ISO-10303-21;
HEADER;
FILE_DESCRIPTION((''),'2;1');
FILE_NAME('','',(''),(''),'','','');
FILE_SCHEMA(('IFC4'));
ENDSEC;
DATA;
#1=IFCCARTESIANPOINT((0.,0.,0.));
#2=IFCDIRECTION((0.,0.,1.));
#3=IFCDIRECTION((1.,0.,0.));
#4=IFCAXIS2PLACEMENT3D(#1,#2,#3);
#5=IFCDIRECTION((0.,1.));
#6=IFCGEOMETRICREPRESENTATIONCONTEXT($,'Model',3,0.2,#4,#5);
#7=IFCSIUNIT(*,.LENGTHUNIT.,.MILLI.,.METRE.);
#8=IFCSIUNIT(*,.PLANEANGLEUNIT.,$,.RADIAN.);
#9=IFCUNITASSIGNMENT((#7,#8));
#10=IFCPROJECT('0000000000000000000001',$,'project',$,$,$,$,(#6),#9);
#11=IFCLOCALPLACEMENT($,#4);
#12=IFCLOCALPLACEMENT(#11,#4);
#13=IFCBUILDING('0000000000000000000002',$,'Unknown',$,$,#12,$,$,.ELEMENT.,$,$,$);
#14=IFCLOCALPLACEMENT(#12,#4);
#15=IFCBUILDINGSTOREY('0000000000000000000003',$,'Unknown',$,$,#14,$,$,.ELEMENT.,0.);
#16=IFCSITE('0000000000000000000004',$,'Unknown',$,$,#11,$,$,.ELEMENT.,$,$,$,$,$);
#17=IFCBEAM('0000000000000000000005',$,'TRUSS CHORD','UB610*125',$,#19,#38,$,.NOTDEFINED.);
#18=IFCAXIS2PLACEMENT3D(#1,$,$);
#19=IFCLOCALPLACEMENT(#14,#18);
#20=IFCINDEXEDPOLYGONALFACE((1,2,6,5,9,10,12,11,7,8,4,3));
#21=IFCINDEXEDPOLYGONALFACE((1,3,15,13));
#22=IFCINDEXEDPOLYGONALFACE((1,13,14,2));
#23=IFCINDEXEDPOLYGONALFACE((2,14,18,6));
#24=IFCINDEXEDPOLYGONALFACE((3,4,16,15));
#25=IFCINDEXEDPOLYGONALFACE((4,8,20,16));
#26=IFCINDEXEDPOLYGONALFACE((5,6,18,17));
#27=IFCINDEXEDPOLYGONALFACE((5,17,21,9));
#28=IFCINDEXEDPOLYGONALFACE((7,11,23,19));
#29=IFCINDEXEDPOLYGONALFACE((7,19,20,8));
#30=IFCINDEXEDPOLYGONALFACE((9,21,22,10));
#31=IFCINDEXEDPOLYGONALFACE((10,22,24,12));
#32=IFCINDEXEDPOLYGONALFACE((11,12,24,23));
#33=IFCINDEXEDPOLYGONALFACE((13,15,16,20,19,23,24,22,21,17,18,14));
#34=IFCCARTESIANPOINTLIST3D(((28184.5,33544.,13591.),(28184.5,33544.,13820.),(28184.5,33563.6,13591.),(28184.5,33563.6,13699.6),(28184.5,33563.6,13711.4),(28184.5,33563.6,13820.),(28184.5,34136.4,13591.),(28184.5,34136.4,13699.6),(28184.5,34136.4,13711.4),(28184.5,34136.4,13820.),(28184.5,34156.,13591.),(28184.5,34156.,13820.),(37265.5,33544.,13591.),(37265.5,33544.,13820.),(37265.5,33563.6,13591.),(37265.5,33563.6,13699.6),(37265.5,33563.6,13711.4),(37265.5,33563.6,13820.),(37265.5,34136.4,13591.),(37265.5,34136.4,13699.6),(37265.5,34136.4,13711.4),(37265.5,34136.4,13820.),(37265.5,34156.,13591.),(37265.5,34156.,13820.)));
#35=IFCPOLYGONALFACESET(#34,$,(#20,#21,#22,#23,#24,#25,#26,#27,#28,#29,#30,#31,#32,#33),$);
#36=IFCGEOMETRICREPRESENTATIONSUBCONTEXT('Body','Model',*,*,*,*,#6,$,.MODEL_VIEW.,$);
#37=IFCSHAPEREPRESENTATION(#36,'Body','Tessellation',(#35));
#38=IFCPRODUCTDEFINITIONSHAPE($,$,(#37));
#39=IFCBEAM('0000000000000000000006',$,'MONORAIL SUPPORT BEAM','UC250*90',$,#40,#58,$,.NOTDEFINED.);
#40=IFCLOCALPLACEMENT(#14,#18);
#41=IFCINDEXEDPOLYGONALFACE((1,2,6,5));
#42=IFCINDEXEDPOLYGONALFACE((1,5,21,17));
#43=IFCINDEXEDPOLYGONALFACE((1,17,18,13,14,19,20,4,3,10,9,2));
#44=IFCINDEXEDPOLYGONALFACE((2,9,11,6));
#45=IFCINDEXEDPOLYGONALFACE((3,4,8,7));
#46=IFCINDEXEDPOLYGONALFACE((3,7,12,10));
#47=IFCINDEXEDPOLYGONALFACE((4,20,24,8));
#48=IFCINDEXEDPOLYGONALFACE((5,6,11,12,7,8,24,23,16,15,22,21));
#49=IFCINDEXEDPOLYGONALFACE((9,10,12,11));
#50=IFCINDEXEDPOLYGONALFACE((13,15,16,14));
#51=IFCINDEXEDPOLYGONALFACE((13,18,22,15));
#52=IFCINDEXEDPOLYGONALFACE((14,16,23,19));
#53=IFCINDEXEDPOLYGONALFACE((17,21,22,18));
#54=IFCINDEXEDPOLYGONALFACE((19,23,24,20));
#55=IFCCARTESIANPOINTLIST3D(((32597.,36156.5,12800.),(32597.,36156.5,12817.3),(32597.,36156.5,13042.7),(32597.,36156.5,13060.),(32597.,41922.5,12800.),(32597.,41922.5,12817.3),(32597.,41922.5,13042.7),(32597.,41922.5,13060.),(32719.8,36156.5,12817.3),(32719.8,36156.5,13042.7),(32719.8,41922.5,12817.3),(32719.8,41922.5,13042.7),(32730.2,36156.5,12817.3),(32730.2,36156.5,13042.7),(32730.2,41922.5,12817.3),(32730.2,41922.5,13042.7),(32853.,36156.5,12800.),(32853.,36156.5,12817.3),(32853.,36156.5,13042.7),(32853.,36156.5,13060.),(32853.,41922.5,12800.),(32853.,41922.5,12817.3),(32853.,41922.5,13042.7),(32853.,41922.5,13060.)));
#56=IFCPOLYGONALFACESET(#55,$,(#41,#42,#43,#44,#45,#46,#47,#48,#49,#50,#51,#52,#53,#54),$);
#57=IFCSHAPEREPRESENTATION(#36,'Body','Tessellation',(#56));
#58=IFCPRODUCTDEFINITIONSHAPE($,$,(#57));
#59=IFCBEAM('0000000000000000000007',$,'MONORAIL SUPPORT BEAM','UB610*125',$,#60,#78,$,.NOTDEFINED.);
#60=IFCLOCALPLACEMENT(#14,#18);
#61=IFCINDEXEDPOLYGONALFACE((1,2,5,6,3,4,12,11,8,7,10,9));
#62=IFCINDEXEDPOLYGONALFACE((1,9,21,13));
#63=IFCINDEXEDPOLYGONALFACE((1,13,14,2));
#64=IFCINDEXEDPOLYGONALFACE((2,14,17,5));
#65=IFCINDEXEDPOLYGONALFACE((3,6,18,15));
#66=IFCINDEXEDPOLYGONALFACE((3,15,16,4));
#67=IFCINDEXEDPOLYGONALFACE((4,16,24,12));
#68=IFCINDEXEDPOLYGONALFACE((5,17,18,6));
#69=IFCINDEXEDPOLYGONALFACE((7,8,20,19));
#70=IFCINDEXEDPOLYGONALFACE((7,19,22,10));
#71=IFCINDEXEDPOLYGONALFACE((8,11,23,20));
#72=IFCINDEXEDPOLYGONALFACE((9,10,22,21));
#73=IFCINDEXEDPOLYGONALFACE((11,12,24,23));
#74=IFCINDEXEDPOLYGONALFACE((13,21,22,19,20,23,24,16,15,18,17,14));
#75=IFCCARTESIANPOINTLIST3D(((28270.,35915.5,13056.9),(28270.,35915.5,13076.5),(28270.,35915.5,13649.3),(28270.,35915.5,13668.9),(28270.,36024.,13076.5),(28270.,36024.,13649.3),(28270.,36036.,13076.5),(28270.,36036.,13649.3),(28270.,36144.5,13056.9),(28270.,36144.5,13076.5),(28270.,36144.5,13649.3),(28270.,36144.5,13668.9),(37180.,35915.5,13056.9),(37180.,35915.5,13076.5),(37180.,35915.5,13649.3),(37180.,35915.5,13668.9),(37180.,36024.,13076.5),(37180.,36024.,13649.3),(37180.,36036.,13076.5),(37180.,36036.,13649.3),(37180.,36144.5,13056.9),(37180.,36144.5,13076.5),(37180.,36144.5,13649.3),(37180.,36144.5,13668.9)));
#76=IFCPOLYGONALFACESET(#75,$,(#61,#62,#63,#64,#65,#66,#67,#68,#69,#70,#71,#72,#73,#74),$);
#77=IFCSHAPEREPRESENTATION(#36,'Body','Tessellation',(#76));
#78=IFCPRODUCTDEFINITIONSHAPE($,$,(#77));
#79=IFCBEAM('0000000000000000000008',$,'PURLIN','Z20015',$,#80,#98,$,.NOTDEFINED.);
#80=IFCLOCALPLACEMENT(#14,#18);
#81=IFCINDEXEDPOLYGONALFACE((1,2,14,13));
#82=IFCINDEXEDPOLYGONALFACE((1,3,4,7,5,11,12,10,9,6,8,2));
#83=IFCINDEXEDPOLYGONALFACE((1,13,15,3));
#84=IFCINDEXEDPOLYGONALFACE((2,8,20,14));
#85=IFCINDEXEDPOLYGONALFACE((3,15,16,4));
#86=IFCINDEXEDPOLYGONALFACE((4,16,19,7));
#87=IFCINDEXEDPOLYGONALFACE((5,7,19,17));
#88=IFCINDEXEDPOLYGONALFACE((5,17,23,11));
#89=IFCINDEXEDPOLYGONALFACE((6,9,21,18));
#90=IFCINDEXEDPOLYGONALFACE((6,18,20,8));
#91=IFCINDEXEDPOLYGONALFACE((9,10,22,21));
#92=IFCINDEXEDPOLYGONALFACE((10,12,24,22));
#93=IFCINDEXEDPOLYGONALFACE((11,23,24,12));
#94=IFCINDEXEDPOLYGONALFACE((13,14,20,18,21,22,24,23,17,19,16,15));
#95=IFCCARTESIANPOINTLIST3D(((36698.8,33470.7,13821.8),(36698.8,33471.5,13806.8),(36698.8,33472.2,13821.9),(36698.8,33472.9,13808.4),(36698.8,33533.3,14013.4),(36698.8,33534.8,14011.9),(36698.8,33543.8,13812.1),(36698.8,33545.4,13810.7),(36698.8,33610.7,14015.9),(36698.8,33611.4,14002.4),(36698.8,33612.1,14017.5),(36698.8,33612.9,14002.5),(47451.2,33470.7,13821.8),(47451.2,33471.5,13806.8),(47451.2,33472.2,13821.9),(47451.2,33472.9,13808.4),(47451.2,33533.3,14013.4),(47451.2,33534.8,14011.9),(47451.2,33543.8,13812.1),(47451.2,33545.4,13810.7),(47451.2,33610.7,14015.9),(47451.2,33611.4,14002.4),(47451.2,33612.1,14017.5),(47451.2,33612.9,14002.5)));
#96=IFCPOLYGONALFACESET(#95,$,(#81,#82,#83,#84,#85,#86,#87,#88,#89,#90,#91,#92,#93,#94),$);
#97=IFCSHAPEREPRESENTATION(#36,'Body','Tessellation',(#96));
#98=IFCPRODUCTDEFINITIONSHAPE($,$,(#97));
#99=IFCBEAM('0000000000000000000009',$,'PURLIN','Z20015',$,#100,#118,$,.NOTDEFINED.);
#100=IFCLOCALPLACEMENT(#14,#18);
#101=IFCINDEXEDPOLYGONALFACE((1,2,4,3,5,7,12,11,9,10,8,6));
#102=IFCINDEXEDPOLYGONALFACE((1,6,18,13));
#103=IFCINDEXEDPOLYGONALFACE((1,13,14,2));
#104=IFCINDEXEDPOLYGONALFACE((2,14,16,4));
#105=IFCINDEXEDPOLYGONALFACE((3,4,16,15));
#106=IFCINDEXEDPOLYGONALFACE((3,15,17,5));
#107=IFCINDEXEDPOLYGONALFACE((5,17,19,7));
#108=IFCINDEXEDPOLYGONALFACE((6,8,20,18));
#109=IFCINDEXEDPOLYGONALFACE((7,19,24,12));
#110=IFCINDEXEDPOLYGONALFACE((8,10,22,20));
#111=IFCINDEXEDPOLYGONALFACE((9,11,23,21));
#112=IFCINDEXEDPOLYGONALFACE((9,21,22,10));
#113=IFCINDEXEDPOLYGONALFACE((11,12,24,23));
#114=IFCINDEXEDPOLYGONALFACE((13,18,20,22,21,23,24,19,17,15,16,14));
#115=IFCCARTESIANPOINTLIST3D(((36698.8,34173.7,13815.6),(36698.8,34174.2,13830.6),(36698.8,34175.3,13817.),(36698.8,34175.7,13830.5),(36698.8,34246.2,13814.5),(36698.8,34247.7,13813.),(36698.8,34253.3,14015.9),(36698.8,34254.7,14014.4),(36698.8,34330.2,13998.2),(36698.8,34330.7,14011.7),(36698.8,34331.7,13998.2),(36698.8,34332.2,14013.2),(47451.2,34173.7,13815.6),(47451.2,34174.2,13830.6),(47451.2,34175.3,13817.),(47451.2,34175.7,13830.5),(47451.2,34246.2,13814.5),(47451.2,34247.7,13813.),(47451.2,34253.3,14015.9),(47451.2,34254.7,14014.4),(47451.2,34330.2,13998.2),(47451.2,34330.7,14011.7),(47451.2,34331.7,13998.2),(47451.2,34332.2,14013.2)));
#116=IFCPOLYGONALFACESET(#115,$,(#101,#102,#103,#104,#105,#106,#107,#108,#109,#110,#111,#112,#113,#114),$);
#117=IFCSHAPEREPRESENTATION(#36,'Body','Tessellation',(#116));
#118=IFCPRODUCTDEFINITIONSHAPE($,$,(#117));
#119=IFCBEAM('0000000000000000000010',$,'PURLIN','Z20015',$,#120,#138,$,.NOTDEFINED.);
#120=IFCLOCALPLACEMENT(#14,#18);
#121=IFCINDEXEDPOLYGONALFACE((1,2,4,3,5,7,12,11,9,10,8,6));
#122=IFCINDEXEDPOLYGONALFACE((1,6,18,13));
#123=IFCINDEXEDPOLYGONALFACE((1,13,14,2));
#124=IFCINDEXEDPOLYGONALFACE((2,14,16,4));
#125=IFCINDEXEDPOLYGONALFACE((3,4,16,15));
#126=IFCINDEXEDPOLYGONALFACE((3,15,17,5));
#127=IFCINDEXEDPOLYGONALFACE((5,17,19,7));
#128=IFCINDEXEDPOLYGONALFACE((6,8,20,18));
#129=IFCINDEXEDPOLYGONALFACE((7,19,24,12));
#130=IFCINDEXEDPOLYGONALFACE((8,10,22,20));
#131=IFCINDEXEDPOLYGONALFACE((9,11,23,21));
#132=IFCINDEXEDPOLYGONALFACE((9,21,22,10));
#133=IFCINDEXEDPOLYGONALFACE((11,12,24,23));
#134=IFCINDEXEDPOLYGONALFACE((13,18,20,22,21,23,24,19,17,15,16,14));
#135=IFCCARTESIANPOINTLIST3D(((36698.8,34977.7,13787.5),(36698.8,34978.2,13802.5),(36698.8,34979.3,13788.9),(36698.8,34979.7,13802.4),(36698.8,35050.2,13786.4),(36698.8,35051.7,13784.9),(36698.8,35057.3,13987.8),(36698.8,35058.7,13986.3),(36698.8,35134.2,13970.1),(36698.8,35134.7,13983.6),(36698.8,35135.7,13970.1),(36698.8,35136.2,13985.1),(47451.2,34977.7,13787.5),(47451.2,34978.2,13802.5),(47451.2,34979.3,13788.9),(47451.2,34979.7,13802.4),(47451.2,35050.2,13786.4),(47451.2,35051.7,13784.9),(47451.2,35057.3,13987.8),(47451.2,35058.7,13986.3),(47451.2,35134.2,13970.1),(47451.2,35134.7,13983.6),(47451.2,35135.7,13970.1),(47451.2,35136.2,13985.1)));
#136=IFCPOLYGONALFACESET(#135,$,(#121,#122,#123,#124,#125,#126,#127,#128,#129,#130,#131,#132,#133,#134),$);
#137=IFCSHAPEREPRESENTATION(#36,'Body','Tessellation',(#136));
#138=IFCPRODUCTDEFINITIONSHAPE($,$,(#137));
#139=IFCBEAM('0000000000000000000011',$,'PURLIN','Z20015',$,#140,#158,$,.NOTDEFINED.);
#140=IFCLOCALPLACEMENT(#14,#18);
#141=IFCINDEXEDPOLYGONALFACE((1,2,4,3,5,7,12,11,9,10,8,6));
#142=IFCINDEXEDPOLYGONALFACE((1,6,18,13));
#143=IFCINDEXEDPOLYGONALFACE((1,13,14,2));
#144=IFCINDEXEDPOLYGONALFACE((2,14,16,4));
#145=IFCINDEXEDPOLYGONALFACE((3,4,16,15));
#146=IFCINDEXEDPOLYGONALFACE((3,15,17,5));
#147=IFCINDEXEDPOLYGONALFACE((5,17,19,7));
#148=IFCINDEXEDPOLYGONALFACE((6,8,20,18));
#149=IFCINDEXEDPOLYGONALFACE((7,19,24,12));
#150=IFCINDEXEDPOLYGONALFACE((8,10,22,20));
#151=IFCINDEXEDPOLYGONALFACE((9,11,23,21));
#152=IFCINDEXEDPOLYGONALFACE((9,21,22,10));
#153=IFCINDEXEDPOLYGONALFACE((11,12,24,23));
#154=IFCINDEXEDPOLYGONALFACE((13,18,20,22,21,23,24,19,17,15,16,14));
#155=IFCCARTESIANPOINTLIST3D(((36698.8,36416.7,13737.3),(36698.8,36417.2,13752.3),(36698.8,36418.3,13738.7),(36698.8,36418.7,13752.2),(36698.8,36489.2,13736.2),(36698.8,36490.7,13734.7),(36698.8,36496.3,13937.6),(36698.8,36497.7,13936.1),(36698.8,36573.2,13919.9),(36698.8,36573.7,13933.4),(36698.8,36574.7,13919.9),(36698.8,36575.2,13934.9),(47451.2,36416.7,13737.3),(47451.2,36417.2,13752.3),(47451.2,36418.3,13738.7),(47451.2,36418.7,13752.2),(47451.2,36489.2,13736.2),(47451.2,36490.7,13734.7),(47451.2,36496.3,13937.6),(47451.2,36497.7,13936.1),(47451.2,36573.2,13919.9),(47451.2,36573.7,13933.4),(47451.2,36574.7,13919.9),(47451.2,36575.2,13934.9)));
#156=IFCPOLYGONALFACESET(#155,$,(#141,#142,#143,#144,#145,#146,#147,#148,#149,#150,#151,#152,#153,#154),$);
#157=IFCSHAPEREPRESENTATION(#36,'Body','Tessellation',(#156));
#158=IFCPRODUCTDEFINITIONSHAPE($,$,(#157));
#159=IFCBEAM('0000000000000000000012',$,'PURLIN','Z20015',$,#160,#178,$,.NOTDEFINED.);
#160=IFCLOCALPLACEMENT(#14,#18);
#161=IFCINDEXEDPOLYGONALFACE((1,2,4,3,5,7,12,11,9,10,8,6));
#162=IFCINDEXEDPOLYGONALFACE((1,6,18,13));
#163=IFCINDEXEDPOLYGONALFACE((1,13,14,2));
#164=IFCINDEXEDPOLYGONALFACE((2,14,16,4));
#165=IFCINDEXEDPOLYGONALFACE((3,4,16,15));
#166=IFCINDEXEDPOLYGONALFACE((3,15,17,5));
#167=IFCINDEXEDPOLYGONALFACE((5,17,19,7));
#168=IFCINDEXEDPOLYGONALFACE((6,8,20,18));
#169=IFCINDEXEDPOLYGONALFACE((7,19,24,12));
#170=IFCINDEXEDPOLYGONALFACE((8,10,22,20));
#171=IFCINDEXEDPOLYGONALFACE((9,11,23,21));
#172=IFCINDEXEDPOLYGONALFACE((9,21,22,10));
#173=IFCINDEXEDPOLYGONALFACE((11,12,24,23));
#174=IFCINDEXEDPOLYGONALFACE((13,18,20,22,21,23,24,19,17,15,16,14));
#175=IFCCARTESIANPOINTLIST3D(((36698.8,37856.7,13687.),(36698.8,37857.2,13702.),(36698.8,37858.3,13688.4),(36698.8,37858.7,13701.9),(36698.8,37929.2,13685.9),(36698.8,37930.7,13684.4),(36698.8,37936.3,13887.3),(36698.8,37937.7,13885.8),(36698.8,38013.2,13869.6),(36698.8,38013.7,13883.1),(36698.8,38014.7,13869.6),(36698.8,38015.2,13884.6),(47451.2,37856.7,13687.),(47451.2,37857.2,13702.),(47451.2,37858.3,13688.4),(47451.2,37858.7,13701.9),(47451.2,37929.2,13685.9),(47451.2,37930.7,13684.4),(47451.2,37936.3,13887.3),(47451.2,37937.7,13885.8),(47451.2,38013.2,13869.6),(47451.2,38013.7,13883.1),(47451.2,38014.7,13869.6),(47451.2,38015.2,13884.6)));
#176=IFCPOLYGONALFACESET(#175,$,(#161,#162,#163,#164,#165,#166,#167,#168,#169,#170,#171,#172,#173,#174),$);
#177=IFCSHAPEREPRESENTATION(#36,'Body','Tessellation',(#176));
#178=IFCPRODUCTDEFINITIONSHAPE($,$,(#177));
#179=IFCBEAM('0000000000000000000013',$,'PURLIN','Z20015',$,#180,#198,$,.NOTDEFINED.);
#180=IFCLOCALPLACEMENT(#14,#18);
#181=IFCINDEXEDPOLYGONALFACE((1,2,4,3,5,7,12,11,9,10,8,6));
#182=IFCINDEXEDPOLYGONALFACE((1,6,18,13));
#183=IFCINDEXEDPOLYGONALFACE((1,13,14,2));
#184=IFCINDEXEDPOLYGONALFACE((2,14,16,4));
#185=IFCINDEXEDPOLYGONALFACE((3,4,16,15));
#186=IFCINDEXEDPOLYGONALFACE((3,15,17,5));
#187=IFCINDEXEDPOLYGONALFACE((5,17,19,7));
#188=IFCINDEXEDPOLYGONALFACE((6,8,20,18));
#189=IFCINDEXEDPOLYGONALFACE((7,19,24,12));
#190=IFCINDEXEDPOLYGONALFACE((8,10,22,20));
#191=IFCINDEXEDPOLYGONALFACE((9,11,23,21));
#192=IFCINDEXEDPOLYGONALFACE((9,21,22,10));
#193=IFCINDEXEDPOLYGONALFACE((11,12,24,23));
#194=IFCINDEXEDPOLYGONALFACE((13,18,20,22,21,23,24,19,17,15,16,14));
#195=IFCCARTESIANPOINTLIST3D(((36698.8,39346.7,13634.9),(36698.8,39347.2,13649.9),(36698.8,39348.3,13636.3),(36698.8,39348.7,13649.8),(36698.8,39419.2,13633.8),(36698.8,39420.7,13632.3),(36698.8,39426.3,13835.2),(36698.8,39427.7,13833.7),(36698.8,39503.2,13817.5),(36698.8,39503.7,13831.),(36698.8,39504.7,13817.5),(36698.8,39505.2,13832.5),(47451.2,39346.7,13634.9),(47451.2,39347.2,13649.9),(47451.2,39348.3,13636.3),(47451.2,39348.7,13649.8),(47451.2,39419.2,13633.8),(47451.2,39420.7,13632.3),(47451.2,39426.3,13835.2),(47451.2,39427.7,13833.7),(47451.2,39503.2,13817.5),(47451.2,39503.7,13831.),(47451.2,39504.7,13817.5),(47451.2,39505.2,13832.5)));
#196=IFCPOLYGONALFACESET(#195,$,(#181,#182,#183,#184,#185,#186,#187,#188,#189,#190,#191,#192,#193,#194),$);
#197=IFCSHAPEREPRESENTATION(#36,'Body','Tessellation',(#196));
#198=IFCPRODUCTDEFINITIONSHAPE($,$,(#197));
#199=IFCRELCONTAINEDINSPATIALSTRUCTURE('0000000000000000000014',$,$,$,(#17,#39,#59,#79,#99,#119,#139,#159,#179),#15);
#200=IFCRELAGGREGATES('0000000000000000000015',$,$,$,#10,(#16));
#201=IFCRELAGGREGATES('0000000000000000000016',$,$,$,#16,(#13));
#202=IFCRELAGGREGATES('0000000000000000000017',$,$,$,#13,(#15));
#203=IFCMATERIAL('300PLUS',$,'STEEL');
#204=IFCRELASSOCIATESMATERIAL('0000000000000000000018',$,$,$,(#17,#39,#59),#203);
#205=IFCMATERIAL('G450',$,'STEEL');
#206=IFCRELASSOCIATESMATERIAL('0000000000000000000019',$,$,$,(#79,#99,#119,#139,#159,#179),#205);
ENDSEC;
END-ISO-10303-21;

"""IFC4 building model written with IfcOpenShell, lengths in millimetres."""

from ifc_helpers import new_model, si_unit, direction, frame, origin_with_axes, place, context, subcontext, project, spatial, line, indexed_curve, outline, extrude, material, element, save


model = new_model("IFC4")

# Units and contexts
model_context = context("Model", 3, precision=0.2, world=origin_with_axes(), true_north=direction((0.0, 1.0)))
body_context = subcontext(model_context, "Body", "Model", "MODEL_VIEW")
ifc_project = project(units=[si_unit("LENGTHUNIT", "METRE", prefix="MILLI"), si_unit("PLANEANGLEUNIT", "RADIAN")], contexts=[model_context])

# Site, building, storey
site_placement = place(None, origin_with_axes())
site = spatial("IfcSite", under=ifc_project, at=site_placement, Name="Unknown", CompositionType="ELEMENT")
building_placement = place(site_placement, origin_with_axes())
building = spatial("IfcBuilding", under=site, at=building_placement, Name="Unknown", CompositionType="ELEMENT")
storey_placement = place(building_placement, origin_with_axes())
storey = spatial("IfcBuildingStorey", under=building, at=storey_placement, Name="Unknown", CompositionType="ELEMENT", Elevation=0.0)

# Beams
ifc_material_1 = material(Name="300PLUS", Category="STEEL")
beam_1_placement = place(storey_placement, frame((28184.5, 33850.0, 13705.5), z_axis=(0.0, 0.0, 1.0), x_axis=(1.0, 0.0, 0.0)))
element("IfcBeam", 1, at=beam_1_placement, inside=storey, material=ifc_material_1, Name="TRUSS CHORD", Description="UB610*125", PredefinedType="NOTDEFINED", context=body_context, shape_type="SolidModel", body=[
    extrude(outline(indexed_curve([(-114.5, -306.0), (114.5, -306.0), (114.5, -286.4), (6.0, -286.4), (6.0, 286.4), (114.5, 286.4), (114.5, 306.0), (-114.5, 306.0), (-114.5, 286.4), (-6.0, 286.4), (-6.0, -286.4), (-114.5, -286.4)], segments=[line(1, 2, 3, 4, 5, 6, 7, 8, 9, 10, 11, 12, 1)])), frame((0.0, 0.0, 0.0), z_axis=(-1.0, 0.0, 0.0), x_axis=(0.0, 0.0, 1.0)), (0.0, 0.0, -1.0), 9081.0),
])
beam_2_placement = place(storey_placement, frame((32725.0, 36156.5, 12930.0), z_axis=(1.0, 0.0, 0.0), x_axis=(0.0, 1.0, 0.0)))
element("IfcBeam", 2, at=beam_2_placement, inside=storey, material=ifc_material_1, Name="MONORAIL SUPPORT BEAM", Description="UC250*90", PredefinedType="NOTDEFINED", context=body_context, shape_type="SolidModel", body=[
    extrude(outline(indexed_curve([(-128.0, -130.0), (128.0, -130.0), (128.0, -112.7), (5.2, -112.7), (5.2, 112.7), (128.0, 112.7), (128.0, 130.0), (-128.0, 130.0), (-128.0, 112.7), (-5.2, 112.7), (-5.2, -112.7), (-128.0, -112.7)], segments=[line(1, 2, 3, 4, 5, 6, 7, 8, 9, 10, 11, 12, 1)])), frame((0.0, 0.0, 0.0), z_axis=(-1.0, 0.0, 0.0), x_axis=(0.0, 0.0, 1.0)), (0.0, 0.0, -1.0), 5766.0),
])
beam_3_placement = place(storey_placement, frame((28270.0, 36030.0, 13362.9), z_axis=(0.0, -1.0, 0.0), x_axis=(1.0, 0.0, 0.0)))
element("IfcBeam", 3, at=beam_3_placement, inside=storey, material=ifc_material_1, Name="MONORAIL SUPPORT BEAM", Description="UB610*125", PredefinedType="NOTDEFINED", context=body_context, shape_type="SolidModel", body=[
    extrude(outline(indexed_curve([(-114.5, -306.0), (114.5, -306.0), (114.5, -286.4), (6.0, -286.4), (6.0, 286.4), (114.5, 286.4), (114.5, 306.0), (-114.5, 306.0), (-114.5, 286.4), (-6.0, 286.4), (-6.0, -286.4), (-114.5, -286.4)], segments=[line(1, 2, 3, 4, 5, 6, 7, 8, 9, 10, 11, 12, 1)])), frame((0.0, 0.0, 0.0), z_axis=(-1.0, 0.0, 0.0), x_axis=(0.0, 0.0, 1.0)), (0.0, 0.0, -1.0), 8910.0),
])
ifc_material_2 = material(Name="G450", Category="STEEL")
for number, where, z_axis, x_axis, name in (
    (4, (36698.8, 33539.3, 13912.0), (0.0, -0.99863, -0.052336), (1.0, 0.0, 0.0), "PURLIN"),
    (5, (36698.8, 34250.5, 13914.5), (0.0, -0.999391, 0.034899), (1.0, 0.0, 0.0), "PURLIN"),
    (6, (36698.8, 35054.5, 13886.4), (0.0, -0.999391, 0.034899), (1.0, 0.0, 0.0), "PURLIN"),
    (7, (36698.8, 36493.5, 13836.2), (0.0, -0.999391, 0.034899), (1.0, 0.0, 0.0), "PURLIN"),
    (8, (36698.8, 37933.5, 13785.9), (0.0, -0.999391, 0.034899), (1.0, 0.0, 0.0), "PURLIN"),
    (9, (36698.8, 39423.5, 13733.8), (0.0, -0.999391, 0.034899), (1.0, 0.0, 0.0), "PURLIN"),
):
    element("IfcBeam", number, at=place(storey_placement, frame(where, z_axis=z_axis, x_axis=x_axis)), inside=storey, material=ifc_material_2, Name=name, Description="Z20015", PredefinedType="NOTDEFINED", context=body_context, shape_type="SolidModel", body=[
        extrude(outline(indexed_curve([(73.2, -101.5), (73.2, -86.5), (71.8, -86.5), (71.8, -100.0), (0.8, -100.0), (0.8, 101.5), (-78.2, 101.5), (-78.2, 86.5), (-76.8, 86.5), (-76.8, 100.0), (-0.8, 100.0), (-0.8, -101.5)], segments=[line(1, 2, 3, 4, 5, 6, 7, 8, 9, 10, 11, 12, 1)])), frame((0.0, 0.0, 0.0), z_axis=(-1.0, 0.0, 0.0), x_axis=(0.0, 0.0, 1.0)), (0.0, 0.0, -1.0), 10752.4),
    ])

save(model, "model.ifc")
